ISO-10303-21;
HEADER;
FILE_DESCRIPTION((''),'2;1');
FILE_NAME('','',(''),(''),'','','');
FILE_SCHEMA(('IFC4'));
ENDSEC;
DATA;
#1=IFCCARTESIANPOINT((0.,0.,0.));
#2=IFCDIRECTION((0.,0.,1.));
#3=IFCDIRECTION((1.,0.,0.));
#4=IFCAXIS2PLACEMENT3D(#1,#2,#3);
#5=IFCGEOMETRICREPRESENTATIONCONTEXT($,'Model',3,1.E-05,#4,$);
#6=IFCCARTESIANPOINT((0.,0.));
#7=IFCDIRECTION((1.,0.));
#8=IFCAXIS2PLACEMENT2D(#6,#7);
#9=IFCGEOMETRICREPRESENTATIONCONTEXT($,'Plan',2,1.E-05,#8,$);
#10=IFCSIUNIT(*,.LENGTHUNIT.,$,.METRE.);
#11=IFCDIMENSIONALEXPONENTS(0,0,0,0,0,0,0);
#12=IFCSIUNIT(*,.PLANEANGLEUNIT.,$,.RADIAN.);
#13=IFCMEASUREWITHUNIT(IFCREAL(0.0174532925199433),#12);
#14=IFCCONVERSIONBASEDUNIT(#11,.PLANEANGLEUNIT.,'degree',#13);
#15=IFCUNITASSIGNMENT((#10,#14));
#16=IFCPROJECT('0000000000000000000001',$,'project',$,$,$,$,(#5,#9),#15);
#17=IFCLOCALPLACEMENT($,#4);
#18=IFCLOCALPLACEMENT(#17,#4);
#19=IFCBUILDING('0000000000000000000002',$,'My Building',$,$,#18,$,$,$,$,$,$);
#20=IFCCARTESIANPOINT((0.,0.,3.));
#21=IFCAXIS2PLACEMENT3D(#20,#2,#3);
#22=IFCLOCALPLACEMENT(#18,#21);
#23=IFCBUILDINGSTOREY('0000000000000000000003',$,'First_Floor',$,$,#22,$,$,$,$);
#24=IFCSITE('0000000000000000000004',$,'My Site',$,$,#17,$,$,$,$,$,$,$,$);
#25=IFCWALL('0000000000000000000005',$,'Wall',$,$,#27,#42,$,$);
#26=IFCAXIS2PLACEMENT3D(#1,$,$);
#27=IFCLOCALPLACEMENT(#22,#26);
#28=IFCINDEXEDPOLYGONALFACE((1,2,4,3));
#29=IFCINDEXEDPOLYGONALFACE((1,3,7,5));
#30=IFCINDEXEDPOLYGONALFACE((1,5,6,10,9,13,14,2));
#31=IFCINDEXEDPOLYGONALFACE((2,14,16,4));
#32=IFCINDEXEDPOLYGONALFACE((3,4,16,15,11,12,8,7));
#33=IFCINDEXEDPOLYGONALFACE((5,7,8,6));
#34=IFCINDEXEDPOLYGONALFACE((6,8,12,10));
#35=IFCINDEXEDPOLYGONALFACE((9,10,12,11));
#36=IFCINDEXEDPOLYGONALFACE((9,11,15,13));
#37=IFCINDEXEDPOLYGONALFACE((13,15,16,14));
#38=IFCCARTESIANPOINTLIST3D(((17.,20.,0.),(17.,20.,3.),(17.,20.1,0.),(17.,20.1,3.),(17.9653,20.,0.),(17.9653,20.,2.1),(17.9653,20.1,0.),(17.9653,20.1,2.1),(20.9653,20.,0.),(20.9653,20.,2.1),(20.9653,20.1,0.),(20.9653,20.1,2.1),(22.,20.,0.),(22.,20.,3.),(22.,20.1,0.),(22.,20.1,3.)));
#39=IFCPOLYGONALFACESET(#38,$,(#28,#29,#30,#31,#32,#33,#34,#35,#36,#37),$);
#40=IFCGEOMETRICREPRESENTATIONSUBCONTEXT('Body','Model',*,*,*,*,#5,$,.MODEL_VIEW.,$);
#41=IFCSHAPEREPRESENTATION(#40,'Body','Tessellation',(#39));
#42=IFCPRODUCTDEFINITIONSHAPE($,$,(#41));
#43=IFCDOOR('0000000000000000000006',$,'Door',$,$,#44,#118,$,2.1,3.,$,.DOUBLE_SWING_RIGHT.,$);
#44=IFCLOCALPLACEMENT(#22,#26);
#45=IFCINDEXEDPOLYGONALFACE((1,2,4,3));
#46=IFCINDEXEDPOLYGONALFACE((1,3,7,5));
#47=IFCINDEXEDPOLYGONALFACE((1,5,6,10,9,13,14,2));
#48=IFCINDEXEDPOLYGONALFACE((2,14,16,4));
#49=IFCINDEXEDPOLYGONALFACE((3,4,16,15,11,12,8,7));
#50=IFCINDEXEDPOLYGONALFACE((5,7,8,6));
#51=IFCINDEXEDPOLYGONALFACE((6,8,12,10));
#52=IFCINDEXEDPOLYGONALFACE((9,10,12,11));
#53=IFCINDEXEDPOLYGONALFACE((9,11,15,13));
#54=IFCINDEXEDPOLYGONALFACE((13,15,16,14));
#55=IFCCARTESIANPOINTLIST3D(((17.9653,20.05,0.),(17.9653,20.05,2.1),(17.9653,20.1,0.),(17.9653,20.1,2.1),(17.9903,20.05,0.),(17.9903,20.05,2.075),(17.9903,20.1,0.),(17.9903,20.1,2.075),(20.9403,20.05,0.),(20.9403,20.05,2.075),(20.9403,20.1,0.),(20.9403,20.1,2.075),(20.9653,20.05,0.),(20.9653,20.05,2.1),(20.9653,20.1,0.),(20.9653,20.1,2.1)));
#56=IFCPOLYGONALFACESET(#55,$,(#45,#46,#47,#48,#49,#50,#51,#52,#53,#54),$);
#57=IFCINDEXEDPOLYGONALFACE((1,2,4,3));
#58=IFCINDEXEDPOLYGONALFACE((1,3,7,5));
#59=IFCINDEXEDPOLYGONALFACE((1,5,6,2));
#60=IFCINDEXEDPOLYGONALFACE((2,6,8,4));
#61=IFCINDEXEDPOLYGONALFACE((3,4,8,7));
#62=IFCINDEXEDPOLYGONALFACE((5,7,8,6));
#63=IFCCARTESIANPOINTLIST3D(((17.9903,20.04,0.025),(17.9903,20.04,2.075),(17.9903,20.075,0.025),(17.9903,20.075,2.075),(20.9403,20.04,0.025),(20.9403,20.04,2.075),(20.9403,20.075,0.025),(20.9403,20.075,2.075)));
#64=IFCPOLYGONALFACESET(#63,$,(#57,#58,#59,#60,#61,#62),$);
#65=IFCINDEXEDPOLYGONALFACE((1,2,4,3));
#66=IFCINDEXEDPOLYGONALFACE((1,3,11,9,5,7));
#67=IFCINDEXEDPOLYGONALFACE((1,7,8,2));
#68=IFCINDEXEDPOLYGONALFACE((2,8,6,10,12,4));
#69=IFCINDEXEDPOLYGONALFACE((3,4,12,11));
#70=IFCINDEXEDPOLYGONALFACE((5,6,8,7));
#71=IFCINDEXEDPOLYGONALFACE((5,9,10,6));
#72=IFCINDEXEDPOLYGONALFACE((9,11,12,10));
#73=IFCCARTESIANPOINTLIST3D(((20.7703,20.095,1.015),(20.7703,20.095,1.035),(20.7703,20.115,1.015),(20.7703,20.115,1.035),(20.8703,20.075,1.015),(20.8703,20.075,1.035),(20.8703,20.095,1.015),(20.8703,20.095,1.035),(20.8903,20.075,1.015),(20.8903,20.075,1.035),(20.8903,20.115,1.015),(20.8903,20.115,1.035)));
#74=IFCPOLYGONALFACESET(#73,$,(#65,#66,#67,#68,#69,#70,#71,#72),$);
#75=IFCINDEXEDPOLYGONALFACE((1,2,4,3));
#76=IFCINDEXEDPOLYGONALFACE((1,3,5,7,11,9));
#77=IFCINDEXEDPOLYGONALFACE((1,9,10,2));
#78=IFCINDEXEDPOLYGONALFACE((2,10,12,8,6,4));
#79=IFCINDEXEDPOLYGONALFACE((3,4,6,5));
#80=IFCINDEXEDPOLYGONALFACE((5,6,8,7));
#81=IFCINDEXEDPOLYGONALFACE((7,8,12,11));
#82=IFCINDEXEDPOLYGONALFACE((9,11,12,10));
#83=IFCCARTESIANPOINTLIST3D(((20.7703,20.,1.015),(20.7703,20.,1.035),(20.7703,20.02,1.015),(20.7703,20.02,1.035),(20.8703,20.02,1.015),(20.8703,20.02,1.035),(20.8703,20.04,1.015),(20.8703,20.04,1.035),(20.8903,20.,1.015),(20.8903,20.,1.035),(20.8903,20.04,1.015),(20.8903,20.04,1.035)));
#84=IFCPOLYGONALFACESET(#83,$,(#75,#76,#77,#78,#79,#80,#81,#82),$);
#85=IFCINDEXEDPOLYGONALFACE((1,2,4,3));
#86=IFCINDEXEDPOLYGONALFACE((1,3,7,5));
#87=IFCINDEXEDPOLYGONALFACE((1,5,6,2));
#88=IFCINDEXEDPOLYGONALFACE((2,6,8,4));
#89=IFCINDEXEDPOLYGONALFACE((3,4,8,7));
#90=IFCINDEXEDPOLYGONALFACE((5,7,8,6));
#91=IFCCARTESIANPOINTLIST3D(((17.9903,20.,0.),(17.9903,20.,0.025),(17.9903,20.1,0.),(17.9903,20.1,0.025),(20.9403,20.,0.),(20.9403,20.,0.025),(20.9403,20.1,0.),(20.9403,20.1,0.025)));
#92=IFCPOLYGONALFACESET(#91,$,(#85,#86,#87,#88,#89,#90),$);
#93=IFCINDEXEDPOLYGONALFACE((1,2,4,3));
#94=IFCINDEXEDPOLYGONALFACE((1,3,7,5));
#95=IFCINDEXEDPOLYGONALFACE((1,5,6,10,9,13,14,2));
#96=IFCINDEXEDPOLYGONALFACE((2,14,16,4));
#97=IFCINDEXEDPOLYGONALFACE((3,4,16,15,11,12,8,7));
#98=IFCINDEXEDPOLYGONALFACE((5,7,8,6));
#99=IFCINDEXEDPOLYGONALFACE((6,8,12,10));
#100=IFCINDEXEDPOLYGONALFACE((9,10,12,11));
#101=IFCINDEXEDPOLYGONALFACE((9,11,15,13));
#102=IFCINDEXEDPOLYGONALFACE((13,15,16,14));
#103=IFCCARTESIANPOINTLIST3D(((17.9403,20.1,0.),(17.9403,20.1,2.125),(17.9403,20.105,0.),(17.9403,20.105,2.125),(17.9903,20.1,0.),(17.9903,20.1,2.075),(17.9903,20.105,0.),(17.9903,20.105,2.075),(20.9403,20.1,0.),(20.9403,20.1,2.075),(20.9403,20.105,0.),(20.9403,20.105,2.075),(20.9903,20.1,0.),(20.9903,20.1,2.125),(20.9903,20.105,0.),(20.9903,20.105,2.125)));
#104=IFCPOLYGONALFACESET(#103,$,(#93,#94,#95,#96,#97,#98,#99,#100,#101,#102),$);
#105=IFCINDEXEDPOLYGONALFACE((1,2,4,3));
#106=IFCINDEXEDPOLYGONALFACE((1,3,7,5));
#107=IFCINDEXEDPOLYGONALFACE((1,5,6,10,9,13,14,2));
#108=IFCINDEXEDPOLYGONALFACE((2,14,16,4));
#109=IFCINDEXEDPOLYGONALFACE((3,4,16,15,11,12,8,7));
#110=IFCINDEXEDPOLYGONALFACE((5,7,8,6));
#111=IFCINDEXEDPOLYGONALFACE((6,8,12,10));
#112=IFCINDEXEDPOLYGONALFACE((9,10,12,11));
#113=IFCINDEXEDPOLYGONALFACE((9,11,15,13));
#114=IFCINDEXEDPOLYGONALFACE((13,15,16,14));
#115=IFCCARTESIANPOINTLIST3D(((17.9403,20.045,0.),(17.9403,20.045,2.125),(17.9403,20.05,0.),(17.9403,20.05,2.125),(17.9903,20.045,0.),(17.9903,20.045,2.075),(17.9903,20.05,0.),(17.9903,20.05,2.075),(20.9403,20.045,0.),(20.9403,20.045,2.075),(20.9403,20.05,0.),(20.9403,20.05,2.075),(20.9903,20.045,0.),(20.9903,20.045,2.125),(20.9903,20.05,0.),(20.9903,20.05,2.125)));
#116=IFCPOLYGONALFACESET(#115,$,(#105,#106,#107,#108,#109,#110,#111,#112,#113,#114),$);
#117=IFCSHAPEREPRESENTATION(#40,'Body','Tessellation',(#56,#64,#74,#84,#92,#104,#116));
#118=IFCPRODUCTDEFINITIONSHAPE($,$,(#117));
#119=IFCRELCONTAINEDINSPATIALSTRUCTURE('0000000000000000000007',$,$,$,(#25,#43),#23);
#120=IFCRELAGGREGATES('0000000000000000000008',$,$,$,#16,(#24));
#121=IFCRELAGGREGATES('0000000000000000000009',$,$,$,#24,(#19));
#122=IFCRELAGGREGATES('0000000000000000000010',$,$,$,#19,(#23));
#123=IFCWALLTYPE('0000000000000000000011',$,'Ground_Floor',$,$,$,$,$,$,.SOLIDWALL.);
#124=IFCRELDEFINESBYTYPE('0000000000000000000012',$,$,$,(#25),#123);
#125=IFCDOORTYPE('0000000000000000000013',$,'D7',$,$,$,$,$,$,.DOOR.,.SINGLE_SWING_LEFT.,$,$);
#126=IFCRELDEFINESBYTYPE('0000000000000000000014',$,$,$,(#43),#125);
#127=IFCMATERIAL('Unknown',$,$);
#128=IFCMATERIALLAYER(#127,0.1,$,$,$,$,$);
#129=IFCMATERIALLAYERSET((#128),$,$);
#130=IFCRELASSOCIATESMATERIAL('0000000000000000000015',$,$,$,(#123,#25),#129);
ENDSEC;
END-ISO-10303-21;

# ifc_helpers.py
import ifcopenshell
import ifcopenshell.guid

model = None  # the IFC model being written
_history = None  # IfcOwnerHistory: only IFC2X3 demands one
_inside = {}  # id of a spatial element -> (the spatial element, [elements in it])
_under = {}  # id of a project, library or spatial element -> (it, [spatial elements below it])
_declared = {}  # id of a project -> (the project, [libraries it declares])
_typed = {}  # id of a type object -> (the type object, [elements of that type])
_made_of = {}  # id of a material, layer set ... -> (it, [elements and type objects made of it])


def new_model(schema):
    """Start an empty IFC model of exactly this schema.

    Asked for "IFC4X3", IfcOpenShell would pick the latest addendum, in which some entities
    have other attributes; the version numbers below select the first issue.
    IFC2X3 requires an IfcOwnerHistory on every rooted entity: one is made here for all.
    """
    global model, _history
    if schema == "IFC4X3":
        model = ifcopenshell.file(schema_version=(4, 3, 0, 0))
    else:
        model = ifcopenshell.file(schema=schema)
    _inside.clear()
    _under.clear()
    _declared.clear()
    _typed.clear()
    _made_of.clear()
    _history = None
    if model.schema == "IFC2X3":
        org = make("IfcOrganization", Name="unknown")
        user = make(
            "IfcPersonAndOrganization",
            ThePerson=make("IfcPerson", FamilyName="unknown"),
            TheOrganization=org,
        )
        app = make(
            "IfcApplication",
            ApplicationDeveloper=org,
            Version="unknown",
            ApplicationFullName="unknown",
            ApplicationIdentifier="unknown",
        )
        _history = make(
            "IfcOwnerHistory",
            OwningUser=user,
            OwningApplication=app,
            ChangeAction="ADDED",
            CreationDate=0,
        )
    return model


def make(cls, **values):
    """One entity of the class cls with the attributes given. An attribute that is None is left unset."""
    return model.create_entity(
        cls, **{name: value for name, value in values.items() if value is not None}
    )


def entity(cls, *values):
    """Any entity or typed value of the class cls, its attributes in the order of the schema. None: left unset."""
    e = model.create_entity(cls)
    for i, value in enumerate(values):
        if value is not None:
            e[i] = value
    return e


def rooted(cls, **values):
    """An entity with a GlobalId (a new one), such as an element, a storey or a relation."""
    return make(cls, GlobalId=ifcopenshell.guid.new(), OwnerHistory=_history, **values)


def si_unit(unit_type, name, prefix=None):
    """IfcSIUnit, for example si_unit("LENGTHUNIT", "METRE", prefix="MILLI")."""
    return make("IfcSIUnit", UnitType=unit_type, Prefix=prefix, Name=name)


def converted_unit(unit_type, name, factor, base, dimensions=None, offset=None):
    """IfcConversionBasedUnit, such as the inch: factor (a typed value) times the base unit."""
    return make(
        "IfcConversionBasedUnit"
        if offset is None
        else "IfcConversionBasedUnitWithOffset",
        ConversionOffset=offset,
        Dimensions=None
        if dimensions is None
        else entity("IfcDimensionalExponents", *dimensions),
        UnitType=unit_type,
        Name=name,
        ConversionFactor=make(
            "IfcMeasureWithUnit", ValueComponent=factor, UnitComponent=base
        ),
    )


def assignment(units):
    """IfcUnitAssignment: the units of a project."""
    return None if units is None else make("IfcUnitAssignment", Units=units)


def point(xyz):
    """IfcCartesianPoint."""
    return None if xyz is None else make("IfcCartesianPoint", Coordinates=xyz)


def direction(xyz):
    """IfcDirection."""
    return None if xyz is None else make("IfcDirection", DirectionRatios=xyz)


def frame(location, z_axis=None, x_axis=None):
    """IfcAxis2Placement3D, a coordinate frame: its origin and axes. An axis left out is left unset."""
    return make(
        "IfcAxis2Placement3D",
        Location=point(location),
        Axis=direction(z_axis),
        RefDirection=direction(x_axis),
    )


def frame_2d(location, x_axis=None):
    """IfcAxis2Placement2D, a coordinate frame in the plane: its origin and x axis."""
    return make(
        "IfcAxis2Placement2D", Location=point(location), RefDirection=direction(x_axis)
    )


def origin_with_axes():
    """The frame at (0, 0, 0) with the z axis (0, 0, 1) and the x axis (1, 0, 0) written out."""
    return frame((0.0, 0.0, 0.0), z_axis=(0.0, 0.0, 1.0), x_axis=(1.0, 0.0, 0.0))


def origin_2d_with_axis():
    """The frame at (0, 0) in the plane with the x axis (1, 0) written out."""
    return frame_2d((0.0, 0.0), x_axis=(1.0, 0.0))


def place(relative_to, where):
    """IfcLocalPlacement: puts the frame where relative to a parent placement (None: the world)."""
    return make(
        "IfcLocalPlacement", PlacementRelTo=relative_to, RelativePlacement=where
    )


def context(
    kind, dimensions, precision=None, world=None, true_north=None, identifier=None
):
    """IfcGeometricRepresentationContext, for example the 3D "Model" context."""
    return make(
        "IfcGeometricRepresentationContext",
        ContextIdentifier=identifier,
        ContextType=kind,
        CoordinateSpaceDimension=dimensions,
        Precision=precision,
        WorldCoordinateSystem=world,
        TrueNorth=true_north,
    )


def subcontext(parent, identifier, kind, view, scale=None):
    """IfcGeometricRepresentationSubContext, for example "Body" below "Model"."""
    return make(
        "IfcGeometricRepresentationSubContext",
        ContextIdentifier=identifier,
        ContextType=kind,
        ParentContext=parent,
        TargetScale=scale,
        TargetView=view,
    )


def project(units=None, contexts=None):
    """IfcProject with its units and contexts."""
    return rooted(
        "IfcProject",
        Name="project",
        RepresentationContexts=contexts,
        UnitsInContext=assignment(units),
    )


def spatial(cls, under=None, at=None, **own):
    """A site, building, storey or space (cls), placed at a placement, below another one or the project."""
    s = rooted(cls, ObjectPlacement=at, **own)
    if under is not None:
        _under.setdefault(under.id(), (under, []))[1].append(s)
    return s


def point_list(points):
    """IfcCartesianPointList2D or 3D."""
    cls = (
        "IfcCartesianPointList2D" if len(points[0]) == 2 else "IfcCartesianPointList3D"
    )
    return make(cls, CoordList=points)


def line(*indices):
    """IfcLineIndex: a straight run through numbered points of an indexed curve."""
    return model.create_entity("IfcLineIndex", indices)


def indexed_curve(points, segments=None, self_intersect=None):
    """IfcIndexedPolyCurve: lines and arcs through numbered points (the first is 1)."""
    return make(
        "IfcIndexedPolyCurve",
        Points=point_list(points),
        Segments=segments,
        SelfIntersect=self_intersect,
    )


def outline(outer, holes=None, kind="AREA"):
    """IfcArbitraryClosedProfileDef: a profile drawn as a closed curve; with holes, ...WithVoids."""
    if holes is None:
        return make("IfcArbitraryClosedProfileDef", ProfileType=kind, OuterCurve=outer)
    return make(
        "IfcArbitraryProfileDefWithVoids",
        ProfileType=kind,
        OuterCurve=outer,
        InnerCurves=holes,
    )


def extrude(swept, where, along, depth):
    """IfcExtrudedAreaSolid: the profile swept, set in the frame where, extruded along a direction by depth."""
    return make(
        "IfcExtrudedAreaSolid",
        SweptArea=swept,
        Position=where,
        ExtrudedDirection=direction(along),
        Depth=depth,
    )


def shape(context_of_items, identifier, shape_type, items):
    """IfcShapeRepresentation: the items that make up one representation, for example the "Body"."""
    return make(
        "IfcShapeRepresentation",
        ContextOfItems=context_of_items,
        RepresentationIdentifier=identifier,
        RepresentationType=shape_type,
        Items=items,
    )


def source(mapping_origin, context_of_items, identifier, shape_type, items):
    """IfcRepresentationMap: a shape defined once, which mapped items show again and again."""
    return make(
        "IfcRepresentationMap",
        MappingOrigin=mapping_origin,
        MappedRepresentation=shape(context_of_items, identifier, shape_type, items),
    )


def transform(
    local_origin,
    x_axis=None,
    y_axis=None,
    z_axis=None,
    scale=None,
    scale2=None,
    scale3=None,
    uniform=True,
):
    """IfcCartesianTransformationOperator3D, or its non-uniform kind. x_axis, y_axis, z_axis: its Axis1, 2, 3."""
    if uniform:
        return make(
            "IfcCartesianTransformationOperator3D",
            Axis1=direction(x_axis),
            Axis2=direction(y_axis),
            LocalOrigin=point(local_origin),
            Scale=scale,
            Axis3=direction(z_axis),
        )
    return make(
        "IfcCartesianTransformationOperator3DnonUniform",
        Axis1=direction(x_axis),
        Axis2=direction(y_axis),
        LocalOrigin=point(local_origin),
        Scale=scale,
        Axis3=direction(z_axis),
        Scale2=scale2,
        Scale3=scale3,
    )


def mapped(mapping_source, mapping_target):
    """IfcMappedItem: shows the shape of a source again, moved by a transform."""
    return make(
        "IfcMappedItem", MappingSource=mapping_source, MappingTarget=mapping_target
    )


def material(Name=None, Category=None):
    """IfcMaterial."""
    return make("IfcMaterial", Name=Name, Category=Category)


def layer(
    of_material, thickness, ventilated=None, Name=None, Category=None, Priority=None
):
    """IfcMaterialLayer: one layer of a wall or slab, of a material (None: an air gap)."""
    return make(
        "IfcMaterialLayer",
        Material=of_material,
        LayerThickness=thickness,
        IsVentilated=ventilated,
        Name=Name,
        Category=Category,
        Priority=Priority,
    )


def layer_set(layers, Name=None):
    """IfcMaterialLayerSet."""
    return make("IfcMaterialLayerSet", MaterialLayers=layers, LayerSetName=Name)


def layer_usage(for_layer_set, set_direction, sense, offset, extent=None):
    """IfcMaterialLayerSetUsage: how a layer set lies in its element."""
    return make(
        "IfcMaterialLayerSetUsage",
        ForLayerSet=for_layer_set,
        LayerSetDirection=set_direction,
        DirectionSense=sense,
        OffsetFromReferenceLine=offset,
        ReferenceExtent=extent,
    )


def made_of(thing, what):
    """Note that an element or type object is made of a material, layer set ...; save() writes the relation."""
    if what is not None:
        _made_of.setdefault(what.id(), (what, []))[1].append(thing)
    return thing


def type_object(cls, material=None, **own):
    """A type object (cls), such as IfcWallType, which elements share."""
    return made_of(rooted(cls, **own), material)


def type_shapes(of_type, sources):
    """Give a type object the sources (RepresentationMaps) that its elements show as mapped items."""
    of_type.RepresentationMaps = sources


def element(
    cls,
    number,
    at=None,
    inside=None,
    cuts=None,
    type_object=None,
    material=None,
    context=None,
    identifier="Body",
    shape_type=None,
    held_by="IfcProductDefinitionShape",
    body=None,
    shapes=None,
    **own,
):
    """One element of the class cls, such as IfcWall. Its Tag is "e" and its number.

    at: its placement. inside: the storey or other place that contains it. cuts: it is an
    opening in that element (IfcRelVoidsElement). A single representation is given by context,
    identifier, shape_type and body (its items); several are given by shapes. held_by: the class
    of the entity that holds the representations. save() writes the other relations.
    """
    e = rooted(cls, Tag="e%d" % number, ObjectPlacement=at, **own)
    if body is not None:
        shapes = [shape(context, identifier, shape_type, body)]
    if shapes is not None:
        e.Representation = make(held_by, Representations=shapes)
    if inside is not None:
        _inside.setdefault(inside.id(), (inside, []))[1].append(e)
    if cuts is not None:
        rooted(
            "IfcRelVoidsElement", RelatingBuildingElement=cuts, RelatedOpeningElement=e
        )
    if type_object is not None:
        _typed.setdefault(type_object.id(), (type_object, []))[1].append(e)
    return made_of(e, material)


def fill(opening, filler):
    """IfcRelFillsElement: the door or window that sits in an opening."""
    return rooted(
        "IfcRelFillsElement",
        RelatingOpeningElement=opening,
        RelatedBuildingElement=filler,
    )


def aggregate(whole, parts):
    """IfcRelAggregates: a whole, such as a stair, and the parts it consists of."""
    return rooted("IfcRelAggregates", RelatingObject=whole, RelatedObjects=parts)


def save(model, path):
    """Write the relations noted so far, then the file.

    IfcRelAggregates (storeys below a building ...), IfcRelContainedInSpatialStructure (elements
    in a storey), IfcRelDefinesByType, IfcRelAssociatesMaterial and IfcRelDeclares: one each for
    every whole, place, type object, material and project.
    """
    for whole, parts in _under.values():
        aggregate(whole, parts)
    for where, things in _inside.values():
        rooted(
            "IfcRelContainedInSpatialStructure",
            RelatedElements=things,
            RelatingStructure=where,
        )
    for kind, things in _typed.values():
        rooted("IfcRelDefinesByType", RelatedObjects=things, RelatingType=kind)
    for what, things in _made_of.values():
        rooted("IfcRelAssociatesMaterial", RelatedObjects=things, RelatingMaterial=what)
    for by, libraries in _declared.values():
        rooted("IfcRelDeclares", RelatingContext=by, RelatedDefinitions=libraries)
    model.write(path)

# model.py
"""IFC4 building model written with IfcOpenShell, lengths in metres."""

from ifc_helpers import new_model, entity, si_unit, converted_unit, frame, origin_with_axes, origin_2d_with_axis, place, context, subcontext, project, spatial, line, indexed_curve, outline, extrude, shape, source, transform, mapped, material, layer, layer_set, layer_usage, type_object, type_shapes, element, fill, save


model = new_model("IFC4")

# Units and contexts
model_context = context("Model", 3, precision=1e-05, world=origin_with_axes())
plan_context = context("Plan", 2, precision=1e-05, world=origin_2d_with_axis())
body_context_1 = subcontext(model_context, "Body", "Model", "MODEL_VIEW")
body_context_2 = subcontext(plan_context, "Body", "Plan", "PLAN_VIEW")
ifc_project = project(units=[si_unit("LENGTHUNIT", "METRE"), converted_unit("PLANEANGLEUNIT", "degree", entity("IfcReal", 0.0174532925199433), si_unit("PLANEANGLEUNIT", "RADIAN"), dimensions=[0, 0, 0, 0, 0, 0, 0])], contexts=[model_context, plan_context])

# Site, building, storey
site_placement = place(None, origin_with_axes())
site = spatial("IfcSite", under=ifc_project, at=site_placement, Name="My Site")
building_placement = place(site_placement, origin_with_axes())
building = spatial("IfcBuilding", under=site, at=building_placement, Name="My Building")
storey_placement = place(building_placement, frame((0.0, 0.0, 3.0), z_axis=(0.0, 0.0, 1.0), x_axis=(1.0, 0.0, 0.0)))
storey = spatial("IfcBuildingStorey", under=building, at=storey_placement, Name="First_Floor")

# Shared definitions
ifc_material = material(Name="Unknown")

# Shared definitions
ifc_layer = layer(ifc_material, 0.1)
ifc_layer_set = layer_set([ifc_layer])
wall_type = type_object("IfcWallType", Name="Ground_Floor", PredefinedType="SOLIDWALL", material=ifc_layer_set)

# Shared definitions
shared_shape_1 = source(origin_with_axes(), body_context_1, "Body", "SweptSolid", [
    extrude(outline(indexed_curve([(0.0, 0.0), (3.0, 0.0), (3.0, 2.1), (0.0, 2.1)], segments=[line(1, 2, 3, 4, 1)])), frame((0.0, -0.6, 0.0), z_axis=(0.0, -1.0, 0.0), x_axis=(1.0, 0.0, 0.0)), (0.0, 0.0, -1.0), 1.2),
])
door_type_1 = type_object("IfcDoorType", Name="D7", OperationType="SINGLE_SWING_LEFT", PredefinedType="DOOR")
shared_shape_2 = source(origin_with_axes(), body_context_1, "Body", "SweptSolid", [
    extrude(outline(indexed_curve([(0.0, 0.0), (0.0, 2.1), (3.0, 2.1), (3.0, 0.0), (2.975, 0.0), (2.975, 2.075), (0.025, 2.075), (0.025, 0.0)], segments=[line(1, 2, 3, 4, 5, 6, 7, 8, 1)])), frame((0.0, 0.0, 0.0), z_axis=(0.0, -1.0, 0.0), x_axis=(1.0, 0.0, 0.0)), (0.0, 0.0, -1.0), 0.05),
    extrude(outline(indexed_curve([(0.0, 0.0), (2.95, 0.0), (2.95, 0.035), (0.0, 0.035)], segments=[line(1, 2, 3, 4, 1)])), frame((0.025, 0.025, 0.025), z_axis=(0.0, 0.0, 1.0), x_axis=(1.0, 0.0, 0.0)), (0.0, 0.0, 1.0), 2.05),
    extrude(outline(indexed_curve([(0.0, 0.0), (0.0, -0.04), (0.12, -0.04), (0.12, -0.02), (0.02, -0.02), (0.02, 0.0)], segments=[line(1, 2, 3, 4, 5, 6, 1)])), frame((0.075, 0.025, 1.015), z_axis=(0.0, 0.0, 1.0), x_axis=(1.0, 0.0, 0.0)), (0.0, 0.0, 1.0), 0.02),
    extrude(outline(indexed_curve([(0.0, 0.0), (0.0, 0.04), (0.12, 0.04), (0.12, 0.02), (0.02, 0.02), (0.02, 0.0)], segments=[line(1, 2, 3, 4, 5, 6, 1)])), frame((0.075, 0.06, 1.015), z_axis=(0.0, 0.0, 1.0), x_axis=(1.0, 0.0, 0.0)), (0.0, 0.0, 1.0), 0.02),
    extrude(outline(indexed_curve([(0.0, 0.0), (2.95, 0.0), (2.95, 0.1), (0.0, 0.1)], segments=[line(1, 2, 3, 4, 1)])), frame((0.025, 0.0, 0.0), z_axis=(0.0, 0.0, 1.0), x_axis=(1.0, 0.0, 0.0)), (0.0, 0.0, 1.0), 0.025),
    extrude(outline(indexed_curve([(0.0, 0.0), (0.0, 2.125), (3.05, 2.125), (3.05, 0.0), (3.0, 0.0), (3.0, 2.075), (0.05, 2.075), (0.05, 0.0)], segments=[line(1, 2, 3, 4, 5, 6, 7, 8, 1)])), frame((-0.025, -0.005, 0.0), z_axis=(0.0, -1.0, 0.0), x_axis=(1.0, 0.0, 0.0)), (0.0, 0.0, -1.0), 0.005),
    extrude(outline(indexed_curve([(0.0, 0.0), (0.0, 2.125), (3.05, 2.125), (3.05, 0.0), (3.0, 0.0), (3.0, 2.075), (0.05, 2.075), (0.05, 0.0)], segments=[line(1, 2, 3, 4, 5, 6, 7, 8, 1)])), frame((-0.025, 0.05, 0.0), z_axis=(0.0, -1.0, 0.0), x_axis=(1.0, 0.0, 0.0)), (0.0, 0.0, -1.0), 0.005),
])
shared_shape_3 = source(origin_with_axes(), body_context_2, "Body", "Curve2D", [
    entity("IfcIndexedPolyCurve", entity("IfcCartesianPointList2D", [[0.0, 0.0], [0.025, 0.0], [0.025, 0.05], [0.0, 0.05]]), [entity("IfcLineIndex", [1, 2, 3, 4, 1])]),
    entity("IfcIndexedPolyCurve", entity("IfcCartesianPointList2D", [[3.0, 0.0], [2.975, 0.0], [2.975, 0.05], [3.0, 0.05]]), [entity("IfcLineIndex", [1, 2, 3, 4, 1])]),
    entity("IfcIndexedPolyCurve", entity("IfcCartesianPointList2D", [[2.975, 0.05], [2.975, -2.9], [2.94, -2.9]])),
    entity("IfcTrimmedCurve", entity("IfcEllipse", entity("IfcAxis2Placement2D", entity("IfcCartesianPoint", [2.94, 0.05]), entity("IfcDirection", [1.0, 0.0])), 2.915, 2.95), [entity("IfcCartesianPoint", [2.94, 3.0])], [entity("IfcCartesianPoint", [2.94, -2.9])], True, "CARTESIAN"),
    entity("IfcIndexedPolyCurve", entity("IfcCartesianPointList2D", [[2.975, 0.05], [2.94, 0.05], [2.94, 3.0], [2.975, 3.0]]), [entity("IfcLineIndex", [1, 2, 3, 4, 1])]),
])
type_shapes(door_type_1, [shared_shape_2, shared_shape_3])

# Wall, opening, door
ifc_layer_usage_1 = layer_usage(ifc_layer_set, "AXIS2", "POSITIVE", 0.0)
wall_1_placement = place(storey_placement, frame((17.0, 20.0, 0.0), z_axis=(0.0, 0.0, 1.0), x_axis=(1.0, 0.0, 0.0)))
wall_1 = element("IfcWall", 1, at=wall_1_placement, inside=storey, type_object=wall_type, material=ifc_layer_usage_1, Name="Wall", context=body_context_1, shape_type="SweptSolid", body=[
    extrude(outline(indexed_curve([(0.0, 0.0), (0.0, 0.1), (5.0, 0.1), (5.0, 0.0)], segments=[line(1, 2, 3, 4, 1)])), origin_with_axes(), (0.0, 0.0, 1.0), 3.0),
])
opening_1_placement = place(wall_1_placement, frame((3.9653, 0.1, 0.0), z_axis=(0.0, 0.0, 1.0), x_axis=(-1.0, 0.0, 0.0)))
opening_1 = element("IfcOpeningElement", 2, at=opening_1_placement, cuts=wall_1, PredefinedType="OPENING", context=body_context_1, shape_type="MappedRepresentation", body=[
    mapped(shared_shape_1, transform((0.0, 0.0, 0.0), x_axis=(1.0, 0.0, 0.0), y_axis=(0.0, 1.0, 0.0), z_axis=(0.0, 0.0, 1.0), scale=1.0)),
])
door_1_placement = place(opening_1_placement, frame((0.0, 0.0, 0.0), z_axis=(0.0, 0.0, 1.0), x_axis=(1.0, 0.0, 0.0)))
door_1 = element("IfcDoor", 3, at=door_1_placement, inside=storey, type_object=door_type_1, Name="Door", OperationType="DOUBLE_SWING_RIGHT", OverallHeight=2.1, OverallWidth=3.0, shapes=[
    shape(body_context_1, "Body", "MappedRepresentation", [mapped(shared_shape_2, transform((0.0, 0.0, 0.0), x_axis=(1.0, 0.0, 0.0), y_axis=(0.0, 1.0, 0.0), z_axis=(0.0, 0.0, 1.0), scale=1.0))]),
    shape(body_context_2, "Body", "MappedRepresentation", [mapped(shared_shape_3, transform((0.0, 0.0, 0.0), x_axis=(1.0, 0.0, 0.0), y_axis=(0.0, 1.0, 0.0), z_axis=(0.0, 0.0, 1.0), scale=1.0))]),
])
fill(opening_1, door_1)

save(model, "model.ifc")
